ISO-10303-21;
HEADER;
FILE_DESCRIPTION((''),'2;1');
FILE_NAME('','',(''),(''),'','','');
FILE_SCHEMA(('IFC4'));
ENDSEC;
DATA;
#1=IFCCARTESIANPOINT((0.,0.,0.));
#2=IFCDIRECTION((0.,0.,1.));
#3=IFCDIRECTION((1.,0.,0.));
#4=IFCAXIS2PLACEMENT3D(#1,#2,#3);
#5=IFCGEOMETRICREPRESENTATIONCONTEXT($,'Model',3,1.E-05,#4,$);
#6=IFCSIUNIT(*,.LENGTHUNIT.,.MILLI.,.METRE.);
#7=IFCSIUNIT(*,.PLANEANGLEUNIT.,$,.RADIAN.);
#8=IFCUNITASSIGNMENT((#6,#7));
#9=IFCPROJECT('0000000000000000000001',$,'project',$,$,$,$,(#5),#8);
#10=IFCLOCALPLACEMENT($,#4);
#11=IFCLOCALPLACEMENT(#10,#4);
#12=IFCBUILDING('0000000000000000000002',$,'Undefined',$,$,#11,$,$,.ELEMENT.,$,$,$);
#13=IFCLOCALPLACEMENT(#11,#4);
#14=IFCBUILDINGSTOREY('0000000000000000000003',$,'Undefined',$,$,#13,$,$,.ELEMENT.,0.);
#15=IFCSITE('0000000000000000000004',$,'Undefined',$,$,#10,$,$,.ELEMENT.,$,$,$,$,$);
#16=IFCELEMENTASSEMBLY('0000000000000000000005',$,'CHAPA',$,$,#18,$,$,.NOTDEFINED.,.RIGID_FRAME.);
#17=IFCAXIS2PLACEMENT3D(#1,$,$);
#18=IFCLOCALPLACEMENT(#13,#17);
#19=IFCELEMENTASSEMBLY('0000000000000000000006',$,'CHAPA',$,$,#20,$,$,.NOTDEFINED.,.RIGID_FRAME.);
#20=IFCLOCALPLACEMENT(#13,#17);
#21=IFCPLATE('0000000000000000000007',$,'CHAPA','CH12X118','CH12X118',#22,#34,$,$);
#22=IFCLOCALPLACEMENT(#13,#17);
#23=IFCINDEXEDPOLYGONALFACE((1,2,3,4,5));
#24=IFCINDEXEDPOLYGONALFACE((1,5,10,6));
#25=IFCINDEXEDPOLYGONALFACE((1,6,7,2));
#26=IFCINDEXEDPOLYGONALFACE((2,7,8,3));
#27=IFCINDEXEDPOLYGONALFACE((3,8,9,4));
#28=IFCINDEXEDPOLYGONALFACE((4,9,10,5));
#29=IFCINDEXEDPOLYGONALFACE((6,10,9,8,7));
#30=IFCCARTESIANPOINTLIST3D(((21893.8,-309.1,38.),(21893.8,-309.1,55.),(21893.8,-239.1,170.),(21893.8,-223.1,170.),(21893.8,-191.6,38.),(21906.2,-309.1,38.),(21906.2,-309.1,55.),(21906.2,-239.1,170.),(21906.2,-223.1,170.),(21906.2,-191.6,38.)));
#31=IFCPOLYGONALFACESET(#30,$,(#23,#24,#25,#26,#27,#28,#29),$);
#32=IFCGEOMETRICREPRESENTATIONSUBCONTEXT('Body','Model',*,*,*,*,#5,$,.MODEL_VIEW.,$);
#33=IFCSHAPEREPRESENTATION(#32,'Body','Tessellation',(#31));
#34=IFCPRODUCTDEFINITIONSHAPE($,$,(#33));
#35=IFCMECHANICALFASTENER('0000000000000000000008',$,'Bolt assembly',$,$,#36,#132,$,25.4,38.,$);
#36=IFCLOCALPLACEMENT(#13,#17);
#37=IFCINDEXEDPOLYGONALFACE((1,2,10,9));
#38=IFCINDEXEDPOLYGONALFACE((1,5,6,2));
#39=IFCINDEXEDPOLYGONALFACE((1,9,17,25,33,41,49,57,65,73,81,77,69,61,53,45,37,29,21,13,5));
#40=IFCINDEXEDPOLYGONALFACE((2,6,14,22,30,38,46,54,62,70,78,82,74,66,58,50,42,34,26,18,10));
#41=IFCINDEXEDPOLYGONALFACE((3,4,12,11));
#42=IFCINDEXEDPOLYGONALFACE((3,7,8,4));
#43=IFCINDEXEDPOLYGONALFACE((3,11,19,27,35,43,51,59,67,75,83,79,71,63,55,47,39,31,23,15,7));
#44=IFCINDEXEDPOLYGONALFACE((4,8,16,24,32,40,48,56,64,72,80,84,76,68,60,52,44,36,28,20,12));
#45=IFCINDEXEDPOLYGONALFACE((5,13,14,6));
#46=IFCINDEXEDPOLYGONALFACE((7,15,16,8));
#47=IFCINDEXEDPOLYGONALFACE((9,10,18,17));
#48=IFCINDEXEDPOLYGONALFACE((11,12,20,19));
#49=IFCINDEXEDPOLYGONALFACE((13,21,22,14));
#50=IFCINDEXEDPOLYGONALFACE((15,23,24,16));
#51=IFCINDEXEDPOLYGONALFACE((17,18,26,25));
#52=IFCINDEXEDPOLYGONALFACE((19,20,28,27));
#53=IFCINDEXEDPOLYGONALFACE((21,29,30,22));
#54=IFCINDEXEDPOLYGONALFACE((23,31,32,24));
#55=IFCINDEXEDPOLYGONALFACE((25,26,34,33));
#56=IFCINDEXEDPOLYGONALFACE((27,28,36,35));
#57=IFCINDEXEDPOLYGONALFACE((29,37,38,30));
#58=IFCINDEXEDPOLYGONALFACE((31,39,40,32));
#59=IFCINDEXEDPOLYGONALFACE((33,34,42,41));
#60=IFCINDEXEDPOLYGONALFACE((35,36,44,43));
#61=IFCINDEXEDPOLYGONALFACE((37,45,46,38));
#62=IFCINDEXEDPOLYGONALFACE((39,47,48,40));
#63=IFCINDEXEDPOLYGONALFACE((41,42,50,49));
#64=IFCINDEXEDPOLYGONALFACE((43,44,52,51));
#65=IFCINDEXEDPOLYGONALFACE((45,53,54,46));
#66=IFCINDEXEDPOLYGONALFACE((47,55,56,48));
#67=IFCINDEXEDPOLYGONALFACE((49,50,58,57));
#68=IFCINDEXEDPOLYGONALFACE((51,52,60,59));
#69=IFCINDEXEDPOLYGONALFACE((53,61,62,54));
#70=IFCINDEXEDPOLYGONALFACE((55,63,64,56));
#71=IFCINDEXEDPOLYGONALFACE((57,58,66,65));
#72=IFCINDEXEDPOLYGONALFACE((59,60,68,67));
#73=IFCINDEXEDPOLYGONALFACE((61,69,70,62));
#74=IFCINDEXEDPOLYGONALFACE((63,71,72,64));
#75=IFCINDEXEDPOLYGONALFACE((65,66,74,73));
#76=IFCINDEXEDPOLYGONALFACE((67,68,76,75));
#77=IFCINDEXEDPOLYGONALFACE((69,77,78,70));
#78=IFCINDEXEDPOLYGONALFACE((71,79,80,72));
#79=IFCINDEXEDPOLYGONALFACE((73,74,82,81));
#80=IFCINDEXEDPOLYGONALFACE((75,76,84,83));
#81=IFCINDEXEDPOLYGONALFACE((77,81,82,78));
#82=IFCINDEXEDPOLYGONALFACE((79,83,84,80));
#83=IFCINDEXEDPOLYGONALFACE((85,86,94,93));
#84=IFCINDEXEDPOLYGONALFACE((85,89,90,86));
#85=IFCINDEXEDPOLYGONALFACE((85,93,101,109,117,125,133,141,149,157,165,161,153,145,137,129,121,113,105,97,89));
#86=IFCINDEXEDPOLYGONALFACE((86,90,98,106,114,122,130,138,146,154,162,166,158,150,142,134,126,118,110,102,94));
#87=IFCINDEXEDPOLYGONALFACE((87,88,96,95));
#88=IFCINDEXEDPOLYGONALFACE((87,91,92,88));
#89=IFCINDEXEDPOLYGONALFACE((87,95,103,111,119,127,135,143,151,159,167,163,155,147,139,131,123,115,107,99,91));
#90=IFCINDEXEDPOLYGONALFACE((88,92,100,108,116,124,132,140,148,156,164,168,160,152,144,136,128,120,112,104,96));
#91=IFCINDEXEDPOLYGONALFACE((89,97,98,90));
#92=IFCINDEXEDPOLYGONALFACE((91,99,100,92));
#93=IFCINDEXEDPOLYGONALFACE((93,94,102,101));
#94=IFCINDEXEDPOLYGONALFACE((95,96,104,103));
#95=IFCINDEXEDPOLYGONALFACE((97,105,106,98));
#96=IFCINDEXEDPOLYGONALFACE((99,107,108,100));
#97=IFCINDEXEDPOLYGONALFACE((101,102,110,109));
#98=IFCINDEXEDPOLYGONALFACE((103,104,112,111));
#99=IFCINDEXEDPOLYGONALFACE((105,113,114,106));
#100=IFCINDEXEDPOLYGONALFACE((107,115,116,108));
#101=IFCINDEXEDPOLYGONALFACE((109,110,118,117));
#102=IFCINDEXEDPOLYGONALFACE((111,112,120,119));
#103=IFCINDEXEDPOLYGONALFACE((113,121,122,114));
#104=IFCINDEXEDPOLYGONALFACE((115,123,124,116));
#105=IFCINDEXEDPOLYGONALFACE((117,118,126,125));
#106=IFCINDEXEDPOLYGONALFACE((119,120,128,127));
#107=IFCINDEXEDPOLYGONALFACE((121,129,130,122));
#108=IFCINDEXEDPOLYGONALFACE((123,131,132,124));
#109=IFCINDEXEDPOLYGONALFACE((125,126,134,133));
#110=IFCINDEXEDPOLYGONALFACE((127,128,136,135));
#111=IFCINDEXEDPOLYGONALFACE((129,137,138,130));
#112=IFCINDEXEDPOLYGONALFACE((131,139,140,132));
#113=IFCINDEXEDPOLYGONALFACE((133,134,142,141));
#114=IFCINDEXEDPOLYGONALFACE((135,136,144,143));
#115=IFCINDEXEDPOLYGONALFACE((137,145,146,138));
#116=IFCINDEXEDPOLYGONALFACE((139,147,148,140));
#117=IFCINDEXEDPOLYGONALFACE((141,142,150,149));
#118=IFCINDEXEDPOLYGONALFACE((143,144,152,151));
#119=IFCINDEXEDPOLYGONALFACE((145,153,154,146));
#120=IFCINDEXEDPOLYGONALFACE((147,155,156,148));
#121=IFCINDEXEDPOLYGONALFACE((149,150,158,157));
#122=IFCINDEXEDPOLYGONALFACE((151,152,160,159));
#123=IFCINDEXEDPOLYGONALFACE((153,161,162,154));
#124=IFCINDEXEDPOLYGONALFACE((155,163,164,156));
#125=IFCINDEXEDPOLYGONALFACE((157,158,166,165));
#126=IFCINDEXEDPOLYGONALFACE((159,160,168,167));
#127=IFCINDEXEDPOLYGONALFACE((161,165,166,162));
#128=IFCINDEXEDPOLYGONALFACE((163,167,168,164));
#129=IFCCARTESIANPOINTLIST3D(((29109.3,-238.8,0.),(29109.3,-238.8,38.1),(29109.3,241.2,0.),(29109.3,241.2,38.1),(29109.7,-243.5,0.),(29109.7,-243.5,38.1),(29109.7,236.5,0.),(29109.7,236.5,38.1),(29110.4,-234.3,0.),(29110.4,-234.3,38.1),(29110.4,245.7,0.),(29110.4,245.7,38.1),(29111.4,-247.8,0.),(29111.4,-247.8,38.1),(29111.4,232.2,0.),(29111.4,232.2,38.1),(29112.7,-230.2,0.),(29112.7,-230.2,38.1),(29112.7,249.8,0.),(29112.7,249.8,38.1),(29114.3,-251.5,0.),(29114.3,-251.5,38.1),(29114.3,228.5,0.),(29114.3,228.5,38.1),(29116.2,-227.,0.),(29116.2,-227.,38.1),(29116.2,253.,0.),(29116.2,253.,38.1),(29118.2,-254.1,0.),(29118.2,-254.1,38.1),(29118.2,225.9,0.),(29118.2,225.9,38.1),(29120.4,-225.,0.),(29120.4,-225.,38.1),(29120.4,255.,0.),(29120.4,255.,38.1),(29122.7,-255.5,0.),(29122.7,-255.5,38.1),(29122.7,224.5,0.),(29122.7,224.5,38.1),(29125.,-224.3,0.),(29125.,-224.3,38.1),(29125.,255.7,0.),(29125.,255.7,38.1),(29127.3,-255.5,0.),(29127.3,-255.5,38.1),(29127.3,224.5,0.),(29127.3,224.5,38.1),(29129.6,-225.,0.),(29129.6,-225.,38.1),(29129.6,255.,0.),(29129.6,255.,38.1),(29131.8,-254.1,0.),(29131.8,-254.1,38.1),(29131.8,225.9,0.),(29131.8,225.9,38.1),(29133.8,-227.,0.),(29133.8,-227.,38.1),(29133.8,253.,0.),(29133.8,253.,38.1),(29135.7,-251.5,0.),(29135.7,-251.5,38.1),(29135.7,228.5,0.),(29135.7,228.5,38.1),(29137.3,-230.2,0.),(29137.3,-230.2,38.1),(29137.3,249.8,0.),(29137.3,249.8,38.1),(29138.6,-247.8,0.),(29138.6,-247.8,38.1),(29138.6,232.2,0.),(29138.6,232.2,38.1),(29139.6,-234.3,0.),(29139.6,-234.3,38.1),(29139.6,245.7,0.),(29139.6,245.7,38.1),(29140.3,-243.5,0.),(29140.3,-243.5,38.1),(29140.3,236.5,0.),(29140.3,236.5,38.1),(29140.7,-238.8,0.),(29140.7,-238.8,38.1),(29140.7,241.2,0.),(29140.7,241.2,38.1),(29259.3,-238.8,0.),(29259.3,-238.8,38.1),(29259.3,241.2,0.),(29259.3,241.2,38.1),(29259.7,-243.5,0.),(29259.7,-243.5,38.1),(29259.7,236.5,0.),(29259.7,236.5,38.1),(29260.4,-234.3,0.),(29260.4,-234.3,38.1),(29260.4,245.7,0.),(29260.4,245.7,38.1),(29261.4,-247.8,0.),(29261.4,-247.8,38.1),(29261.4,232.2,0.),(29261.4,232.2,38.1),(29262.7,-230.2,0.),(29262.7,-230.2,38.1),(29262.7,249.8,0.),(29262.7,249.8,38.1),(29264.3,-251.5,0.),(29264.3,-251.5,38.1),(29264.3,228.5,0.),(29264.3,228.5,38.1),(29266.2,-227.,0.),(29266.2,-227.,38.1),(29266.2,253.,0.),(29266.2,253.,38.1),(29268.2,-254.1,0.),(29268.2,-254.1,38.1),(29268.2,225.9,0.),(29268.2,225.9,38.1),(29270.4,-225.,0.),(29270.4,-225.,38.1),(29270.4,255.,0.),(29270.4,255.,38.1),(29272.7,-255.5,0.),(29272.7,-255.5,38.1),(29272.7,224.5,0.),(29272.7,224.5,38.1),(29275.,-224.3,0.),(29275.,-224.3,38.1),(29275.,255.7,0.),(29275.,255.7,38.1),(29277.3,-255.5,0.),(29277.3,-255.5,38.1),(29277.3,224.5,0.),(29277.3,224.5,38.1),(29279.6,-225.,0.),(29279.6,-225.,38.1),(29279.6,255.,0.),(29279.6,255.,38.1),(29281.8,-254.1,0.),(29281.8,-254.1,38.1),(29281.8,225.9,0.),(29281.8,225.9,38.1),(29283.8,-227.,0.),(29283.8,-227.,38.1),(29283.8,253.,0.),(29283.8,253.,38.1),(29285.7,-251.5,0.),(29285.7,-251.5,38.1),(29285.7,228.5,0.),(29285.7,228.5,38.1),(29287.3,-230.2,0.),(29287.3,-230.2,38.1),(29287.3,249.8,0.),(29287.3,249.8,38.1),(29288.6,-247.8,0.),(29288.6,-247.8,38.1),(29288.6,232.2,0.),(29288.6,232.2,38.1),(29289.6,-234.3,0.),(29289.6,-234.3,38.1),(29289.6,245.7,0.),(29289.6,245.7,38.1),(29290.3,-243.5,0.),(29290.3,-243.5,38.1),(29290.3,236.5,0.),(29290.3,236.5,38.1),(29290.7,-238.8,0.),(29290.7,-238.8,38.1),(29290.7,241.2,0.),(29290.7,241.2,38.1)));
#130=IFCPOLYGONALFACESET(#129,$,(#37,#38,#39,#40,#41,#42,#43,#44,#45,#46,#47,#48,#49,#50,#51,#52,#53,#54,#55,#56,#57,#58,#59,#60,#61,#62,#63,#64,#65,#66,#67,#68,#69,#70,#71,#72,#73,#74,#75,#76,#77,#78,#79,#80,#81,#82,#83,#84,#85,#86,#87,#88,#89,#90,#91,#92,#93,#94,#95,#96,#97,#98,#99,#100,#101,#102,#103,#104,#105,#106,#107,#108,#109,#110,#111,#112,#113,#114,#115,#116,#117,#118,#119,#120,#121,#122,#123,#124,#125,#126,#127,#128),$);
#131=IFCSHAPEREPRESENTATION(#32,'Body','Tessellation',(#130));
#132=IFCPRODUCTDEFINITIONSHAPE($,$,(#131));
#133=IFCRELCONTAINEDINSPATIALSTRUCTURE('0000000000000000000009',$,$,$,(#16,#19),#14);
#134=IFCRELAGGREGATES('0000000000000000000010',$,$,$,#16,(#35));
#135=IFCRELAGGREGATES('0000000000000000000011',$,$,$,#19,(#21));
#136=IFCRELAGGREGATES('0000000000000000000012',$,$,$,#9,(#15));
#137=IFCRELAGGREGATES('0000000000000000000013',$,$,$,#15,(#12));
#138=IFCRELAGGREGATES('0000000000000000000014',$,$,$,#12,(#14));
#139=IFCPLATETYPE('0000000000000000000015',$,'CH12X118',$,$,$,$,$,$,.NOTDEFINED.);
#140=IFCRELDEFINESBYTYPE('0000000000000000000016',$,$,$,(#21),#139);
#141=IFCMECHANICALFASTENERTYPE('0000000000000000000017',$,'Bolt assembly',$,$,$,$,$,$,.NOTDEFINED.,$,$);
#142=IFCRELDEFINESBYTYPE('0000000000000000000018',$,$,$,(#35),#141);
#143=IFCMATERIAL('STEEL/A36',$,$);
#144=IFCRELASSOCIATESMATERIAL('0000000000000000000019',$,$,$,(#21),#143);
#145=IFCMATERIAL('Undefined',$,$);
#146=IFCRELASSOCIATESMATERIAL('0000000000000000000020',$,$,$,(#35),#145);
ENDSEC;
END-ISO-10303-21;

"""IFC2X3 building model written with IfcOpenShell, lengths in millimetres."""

from ifc_helpers import new_model, si_unit, frame, origin_with_axes, origin_2d_with_axis, place, context, subcontext, project, spatial, polyline, circle, outline, extrude, source, transform, mapped, material, type_object, element, aggregate, save


model = new_model("IFC2X3")

# Units and contexts
model_context = context("Model", 3, precision=1e-05, world=origin_with_axes())
body_context = subcontext(model_context, "Body", "Model", "MODEL_VIEW")
ifc_project = project(units=[si_unit("LENGTHUNIT", "METRE", prefix="MILLI"), si_unit("PLANEANGLEUNIT", "RADIAN")], contexts=[model_context])

# Site, building, storey
site_placement = place(None, origin_with_axes())
site = spatial("IfcSite", under=ifc_project, at=site_placement, Name="Undefined", CompositionType="ELEMENT")
building_placement = place(site_placement, origin_with_axes())
building = spatial("IfcBuilding", under=site, at=building_placement, Name="Undefined", CompositionType="ELEMENT")
storey_placement = place(building_placement, origin_with_axes())
storey = spatial("IfcBuildingStorey", under=building, at=storey_placement, Name="Undefined", CompositionType="ELEMENT", Elevation=0.0)

# Element assemblies
assembly_1_placement = place(storey_placement, origin_with_axes())
assembly_1 = element("IfcElementAssembly", 1, at=assembly_1_placement, inside=storey, Name="CHAPA", AssemblyPlace="NOTDEFINED", PredefinedType="RIGID_FRAME")
assembly_2_placement = place(storey_placement, origin_with_axes())
assembly_2 = element("IfcElementAssembly", 2, at=assembly_2_placement, inside=storey, Name="CHAPA", AssemblyPlace="NOTDEFINED", PredefinedType="RIGID_FRAME")

# Shared definitions
ifc_material_1 = material(Name="STEEL/A36")

# Plate
plate_type_1 = type_object("IfcPlateType", Name="CH12X118", PredefinedType="NOTDEFINED")
plate_1_placement = place(assembly_2_placement, frame((21900.0, -309.1, 38.0), z_axis=(1.0, 0.0, 0.0), x_axis=(0.0, 1.0, 0.0)))
plate_1 = element("IfcPlate", 3, at=plate_1_placement, type_object=plate_type_1, material=ifc_material_1, Name="CHAPA", Description="CH12X118", ObjectType="CH12X118", context=body_context, shape_type="SweptSolid", body=[
    extrude(outline(polyline([(0.0, 0.0), (117.5, 0.0), (85.9, 132.0), (70.0, 132.0), (0.0, 17.0), (0.0, 0.0)])), frame((0.0, 0.0, -6.2), z_axis=(0.0, 0.0, 1.0), x_axis=(1.0, 0.0, 0.0)), (0.0, 0.0, 1.0), 12.5),
])

# Shared definitions
ifc_material_2 = material(Name="Undefined")
mechanical_fastener_type = type_object("IfcMechanicalFastenerType", Name="Bolt assembly")

# Mechanical fastener
shared_shape_1 = source(origin_with_axes(), body_context, "Body", "SweptSolid", [
    extrude(circle(Radius=15.7, at=origin_2d_with_axis()), frame((0.0, -38.0, 0.0), z_axis=(0.0, 1.0, 0.0), x_axis=(1.0, 0.0, 0.0)), (0.0, 0.0, 1.0), 38.1),
])
mechanical_fastener_1_placement = place(assembly_1_placement, frame((29200.0, -240.0, 38.0), z_axis=(1.0, 0.0, 0.0), x_axis=(0.0, 1.0, 0.0)))
mechanical_fastener_1 = element("IfcMechanicalFastener", 4, at=mechanical_fastener_1_placement, type_object=mechanical_fastener_type, material=ifc_material_2, Name="Bolt assembly", NominalDiameter=25.4, NominalLength=38.0, context=body_context, shape_type="MappedRepresentation", body=[
    mapped(shared_shape_1, transform((0.0, 0.0, -75.0))),
    mapped(shared_shape_1, transform((0.0, 0.0, 75.0))),
    mapped(shared_shape_1, transform((480.0, 0.0, -75.0))),
    mapped(shared_shape_1, transform((480.0, 0.0, 75.0))),
])
aggregate(assembly_1, [mechanical_fastener_1])
aggregate(assembly_2, [plate_1])

save(model, "model.ifc")
